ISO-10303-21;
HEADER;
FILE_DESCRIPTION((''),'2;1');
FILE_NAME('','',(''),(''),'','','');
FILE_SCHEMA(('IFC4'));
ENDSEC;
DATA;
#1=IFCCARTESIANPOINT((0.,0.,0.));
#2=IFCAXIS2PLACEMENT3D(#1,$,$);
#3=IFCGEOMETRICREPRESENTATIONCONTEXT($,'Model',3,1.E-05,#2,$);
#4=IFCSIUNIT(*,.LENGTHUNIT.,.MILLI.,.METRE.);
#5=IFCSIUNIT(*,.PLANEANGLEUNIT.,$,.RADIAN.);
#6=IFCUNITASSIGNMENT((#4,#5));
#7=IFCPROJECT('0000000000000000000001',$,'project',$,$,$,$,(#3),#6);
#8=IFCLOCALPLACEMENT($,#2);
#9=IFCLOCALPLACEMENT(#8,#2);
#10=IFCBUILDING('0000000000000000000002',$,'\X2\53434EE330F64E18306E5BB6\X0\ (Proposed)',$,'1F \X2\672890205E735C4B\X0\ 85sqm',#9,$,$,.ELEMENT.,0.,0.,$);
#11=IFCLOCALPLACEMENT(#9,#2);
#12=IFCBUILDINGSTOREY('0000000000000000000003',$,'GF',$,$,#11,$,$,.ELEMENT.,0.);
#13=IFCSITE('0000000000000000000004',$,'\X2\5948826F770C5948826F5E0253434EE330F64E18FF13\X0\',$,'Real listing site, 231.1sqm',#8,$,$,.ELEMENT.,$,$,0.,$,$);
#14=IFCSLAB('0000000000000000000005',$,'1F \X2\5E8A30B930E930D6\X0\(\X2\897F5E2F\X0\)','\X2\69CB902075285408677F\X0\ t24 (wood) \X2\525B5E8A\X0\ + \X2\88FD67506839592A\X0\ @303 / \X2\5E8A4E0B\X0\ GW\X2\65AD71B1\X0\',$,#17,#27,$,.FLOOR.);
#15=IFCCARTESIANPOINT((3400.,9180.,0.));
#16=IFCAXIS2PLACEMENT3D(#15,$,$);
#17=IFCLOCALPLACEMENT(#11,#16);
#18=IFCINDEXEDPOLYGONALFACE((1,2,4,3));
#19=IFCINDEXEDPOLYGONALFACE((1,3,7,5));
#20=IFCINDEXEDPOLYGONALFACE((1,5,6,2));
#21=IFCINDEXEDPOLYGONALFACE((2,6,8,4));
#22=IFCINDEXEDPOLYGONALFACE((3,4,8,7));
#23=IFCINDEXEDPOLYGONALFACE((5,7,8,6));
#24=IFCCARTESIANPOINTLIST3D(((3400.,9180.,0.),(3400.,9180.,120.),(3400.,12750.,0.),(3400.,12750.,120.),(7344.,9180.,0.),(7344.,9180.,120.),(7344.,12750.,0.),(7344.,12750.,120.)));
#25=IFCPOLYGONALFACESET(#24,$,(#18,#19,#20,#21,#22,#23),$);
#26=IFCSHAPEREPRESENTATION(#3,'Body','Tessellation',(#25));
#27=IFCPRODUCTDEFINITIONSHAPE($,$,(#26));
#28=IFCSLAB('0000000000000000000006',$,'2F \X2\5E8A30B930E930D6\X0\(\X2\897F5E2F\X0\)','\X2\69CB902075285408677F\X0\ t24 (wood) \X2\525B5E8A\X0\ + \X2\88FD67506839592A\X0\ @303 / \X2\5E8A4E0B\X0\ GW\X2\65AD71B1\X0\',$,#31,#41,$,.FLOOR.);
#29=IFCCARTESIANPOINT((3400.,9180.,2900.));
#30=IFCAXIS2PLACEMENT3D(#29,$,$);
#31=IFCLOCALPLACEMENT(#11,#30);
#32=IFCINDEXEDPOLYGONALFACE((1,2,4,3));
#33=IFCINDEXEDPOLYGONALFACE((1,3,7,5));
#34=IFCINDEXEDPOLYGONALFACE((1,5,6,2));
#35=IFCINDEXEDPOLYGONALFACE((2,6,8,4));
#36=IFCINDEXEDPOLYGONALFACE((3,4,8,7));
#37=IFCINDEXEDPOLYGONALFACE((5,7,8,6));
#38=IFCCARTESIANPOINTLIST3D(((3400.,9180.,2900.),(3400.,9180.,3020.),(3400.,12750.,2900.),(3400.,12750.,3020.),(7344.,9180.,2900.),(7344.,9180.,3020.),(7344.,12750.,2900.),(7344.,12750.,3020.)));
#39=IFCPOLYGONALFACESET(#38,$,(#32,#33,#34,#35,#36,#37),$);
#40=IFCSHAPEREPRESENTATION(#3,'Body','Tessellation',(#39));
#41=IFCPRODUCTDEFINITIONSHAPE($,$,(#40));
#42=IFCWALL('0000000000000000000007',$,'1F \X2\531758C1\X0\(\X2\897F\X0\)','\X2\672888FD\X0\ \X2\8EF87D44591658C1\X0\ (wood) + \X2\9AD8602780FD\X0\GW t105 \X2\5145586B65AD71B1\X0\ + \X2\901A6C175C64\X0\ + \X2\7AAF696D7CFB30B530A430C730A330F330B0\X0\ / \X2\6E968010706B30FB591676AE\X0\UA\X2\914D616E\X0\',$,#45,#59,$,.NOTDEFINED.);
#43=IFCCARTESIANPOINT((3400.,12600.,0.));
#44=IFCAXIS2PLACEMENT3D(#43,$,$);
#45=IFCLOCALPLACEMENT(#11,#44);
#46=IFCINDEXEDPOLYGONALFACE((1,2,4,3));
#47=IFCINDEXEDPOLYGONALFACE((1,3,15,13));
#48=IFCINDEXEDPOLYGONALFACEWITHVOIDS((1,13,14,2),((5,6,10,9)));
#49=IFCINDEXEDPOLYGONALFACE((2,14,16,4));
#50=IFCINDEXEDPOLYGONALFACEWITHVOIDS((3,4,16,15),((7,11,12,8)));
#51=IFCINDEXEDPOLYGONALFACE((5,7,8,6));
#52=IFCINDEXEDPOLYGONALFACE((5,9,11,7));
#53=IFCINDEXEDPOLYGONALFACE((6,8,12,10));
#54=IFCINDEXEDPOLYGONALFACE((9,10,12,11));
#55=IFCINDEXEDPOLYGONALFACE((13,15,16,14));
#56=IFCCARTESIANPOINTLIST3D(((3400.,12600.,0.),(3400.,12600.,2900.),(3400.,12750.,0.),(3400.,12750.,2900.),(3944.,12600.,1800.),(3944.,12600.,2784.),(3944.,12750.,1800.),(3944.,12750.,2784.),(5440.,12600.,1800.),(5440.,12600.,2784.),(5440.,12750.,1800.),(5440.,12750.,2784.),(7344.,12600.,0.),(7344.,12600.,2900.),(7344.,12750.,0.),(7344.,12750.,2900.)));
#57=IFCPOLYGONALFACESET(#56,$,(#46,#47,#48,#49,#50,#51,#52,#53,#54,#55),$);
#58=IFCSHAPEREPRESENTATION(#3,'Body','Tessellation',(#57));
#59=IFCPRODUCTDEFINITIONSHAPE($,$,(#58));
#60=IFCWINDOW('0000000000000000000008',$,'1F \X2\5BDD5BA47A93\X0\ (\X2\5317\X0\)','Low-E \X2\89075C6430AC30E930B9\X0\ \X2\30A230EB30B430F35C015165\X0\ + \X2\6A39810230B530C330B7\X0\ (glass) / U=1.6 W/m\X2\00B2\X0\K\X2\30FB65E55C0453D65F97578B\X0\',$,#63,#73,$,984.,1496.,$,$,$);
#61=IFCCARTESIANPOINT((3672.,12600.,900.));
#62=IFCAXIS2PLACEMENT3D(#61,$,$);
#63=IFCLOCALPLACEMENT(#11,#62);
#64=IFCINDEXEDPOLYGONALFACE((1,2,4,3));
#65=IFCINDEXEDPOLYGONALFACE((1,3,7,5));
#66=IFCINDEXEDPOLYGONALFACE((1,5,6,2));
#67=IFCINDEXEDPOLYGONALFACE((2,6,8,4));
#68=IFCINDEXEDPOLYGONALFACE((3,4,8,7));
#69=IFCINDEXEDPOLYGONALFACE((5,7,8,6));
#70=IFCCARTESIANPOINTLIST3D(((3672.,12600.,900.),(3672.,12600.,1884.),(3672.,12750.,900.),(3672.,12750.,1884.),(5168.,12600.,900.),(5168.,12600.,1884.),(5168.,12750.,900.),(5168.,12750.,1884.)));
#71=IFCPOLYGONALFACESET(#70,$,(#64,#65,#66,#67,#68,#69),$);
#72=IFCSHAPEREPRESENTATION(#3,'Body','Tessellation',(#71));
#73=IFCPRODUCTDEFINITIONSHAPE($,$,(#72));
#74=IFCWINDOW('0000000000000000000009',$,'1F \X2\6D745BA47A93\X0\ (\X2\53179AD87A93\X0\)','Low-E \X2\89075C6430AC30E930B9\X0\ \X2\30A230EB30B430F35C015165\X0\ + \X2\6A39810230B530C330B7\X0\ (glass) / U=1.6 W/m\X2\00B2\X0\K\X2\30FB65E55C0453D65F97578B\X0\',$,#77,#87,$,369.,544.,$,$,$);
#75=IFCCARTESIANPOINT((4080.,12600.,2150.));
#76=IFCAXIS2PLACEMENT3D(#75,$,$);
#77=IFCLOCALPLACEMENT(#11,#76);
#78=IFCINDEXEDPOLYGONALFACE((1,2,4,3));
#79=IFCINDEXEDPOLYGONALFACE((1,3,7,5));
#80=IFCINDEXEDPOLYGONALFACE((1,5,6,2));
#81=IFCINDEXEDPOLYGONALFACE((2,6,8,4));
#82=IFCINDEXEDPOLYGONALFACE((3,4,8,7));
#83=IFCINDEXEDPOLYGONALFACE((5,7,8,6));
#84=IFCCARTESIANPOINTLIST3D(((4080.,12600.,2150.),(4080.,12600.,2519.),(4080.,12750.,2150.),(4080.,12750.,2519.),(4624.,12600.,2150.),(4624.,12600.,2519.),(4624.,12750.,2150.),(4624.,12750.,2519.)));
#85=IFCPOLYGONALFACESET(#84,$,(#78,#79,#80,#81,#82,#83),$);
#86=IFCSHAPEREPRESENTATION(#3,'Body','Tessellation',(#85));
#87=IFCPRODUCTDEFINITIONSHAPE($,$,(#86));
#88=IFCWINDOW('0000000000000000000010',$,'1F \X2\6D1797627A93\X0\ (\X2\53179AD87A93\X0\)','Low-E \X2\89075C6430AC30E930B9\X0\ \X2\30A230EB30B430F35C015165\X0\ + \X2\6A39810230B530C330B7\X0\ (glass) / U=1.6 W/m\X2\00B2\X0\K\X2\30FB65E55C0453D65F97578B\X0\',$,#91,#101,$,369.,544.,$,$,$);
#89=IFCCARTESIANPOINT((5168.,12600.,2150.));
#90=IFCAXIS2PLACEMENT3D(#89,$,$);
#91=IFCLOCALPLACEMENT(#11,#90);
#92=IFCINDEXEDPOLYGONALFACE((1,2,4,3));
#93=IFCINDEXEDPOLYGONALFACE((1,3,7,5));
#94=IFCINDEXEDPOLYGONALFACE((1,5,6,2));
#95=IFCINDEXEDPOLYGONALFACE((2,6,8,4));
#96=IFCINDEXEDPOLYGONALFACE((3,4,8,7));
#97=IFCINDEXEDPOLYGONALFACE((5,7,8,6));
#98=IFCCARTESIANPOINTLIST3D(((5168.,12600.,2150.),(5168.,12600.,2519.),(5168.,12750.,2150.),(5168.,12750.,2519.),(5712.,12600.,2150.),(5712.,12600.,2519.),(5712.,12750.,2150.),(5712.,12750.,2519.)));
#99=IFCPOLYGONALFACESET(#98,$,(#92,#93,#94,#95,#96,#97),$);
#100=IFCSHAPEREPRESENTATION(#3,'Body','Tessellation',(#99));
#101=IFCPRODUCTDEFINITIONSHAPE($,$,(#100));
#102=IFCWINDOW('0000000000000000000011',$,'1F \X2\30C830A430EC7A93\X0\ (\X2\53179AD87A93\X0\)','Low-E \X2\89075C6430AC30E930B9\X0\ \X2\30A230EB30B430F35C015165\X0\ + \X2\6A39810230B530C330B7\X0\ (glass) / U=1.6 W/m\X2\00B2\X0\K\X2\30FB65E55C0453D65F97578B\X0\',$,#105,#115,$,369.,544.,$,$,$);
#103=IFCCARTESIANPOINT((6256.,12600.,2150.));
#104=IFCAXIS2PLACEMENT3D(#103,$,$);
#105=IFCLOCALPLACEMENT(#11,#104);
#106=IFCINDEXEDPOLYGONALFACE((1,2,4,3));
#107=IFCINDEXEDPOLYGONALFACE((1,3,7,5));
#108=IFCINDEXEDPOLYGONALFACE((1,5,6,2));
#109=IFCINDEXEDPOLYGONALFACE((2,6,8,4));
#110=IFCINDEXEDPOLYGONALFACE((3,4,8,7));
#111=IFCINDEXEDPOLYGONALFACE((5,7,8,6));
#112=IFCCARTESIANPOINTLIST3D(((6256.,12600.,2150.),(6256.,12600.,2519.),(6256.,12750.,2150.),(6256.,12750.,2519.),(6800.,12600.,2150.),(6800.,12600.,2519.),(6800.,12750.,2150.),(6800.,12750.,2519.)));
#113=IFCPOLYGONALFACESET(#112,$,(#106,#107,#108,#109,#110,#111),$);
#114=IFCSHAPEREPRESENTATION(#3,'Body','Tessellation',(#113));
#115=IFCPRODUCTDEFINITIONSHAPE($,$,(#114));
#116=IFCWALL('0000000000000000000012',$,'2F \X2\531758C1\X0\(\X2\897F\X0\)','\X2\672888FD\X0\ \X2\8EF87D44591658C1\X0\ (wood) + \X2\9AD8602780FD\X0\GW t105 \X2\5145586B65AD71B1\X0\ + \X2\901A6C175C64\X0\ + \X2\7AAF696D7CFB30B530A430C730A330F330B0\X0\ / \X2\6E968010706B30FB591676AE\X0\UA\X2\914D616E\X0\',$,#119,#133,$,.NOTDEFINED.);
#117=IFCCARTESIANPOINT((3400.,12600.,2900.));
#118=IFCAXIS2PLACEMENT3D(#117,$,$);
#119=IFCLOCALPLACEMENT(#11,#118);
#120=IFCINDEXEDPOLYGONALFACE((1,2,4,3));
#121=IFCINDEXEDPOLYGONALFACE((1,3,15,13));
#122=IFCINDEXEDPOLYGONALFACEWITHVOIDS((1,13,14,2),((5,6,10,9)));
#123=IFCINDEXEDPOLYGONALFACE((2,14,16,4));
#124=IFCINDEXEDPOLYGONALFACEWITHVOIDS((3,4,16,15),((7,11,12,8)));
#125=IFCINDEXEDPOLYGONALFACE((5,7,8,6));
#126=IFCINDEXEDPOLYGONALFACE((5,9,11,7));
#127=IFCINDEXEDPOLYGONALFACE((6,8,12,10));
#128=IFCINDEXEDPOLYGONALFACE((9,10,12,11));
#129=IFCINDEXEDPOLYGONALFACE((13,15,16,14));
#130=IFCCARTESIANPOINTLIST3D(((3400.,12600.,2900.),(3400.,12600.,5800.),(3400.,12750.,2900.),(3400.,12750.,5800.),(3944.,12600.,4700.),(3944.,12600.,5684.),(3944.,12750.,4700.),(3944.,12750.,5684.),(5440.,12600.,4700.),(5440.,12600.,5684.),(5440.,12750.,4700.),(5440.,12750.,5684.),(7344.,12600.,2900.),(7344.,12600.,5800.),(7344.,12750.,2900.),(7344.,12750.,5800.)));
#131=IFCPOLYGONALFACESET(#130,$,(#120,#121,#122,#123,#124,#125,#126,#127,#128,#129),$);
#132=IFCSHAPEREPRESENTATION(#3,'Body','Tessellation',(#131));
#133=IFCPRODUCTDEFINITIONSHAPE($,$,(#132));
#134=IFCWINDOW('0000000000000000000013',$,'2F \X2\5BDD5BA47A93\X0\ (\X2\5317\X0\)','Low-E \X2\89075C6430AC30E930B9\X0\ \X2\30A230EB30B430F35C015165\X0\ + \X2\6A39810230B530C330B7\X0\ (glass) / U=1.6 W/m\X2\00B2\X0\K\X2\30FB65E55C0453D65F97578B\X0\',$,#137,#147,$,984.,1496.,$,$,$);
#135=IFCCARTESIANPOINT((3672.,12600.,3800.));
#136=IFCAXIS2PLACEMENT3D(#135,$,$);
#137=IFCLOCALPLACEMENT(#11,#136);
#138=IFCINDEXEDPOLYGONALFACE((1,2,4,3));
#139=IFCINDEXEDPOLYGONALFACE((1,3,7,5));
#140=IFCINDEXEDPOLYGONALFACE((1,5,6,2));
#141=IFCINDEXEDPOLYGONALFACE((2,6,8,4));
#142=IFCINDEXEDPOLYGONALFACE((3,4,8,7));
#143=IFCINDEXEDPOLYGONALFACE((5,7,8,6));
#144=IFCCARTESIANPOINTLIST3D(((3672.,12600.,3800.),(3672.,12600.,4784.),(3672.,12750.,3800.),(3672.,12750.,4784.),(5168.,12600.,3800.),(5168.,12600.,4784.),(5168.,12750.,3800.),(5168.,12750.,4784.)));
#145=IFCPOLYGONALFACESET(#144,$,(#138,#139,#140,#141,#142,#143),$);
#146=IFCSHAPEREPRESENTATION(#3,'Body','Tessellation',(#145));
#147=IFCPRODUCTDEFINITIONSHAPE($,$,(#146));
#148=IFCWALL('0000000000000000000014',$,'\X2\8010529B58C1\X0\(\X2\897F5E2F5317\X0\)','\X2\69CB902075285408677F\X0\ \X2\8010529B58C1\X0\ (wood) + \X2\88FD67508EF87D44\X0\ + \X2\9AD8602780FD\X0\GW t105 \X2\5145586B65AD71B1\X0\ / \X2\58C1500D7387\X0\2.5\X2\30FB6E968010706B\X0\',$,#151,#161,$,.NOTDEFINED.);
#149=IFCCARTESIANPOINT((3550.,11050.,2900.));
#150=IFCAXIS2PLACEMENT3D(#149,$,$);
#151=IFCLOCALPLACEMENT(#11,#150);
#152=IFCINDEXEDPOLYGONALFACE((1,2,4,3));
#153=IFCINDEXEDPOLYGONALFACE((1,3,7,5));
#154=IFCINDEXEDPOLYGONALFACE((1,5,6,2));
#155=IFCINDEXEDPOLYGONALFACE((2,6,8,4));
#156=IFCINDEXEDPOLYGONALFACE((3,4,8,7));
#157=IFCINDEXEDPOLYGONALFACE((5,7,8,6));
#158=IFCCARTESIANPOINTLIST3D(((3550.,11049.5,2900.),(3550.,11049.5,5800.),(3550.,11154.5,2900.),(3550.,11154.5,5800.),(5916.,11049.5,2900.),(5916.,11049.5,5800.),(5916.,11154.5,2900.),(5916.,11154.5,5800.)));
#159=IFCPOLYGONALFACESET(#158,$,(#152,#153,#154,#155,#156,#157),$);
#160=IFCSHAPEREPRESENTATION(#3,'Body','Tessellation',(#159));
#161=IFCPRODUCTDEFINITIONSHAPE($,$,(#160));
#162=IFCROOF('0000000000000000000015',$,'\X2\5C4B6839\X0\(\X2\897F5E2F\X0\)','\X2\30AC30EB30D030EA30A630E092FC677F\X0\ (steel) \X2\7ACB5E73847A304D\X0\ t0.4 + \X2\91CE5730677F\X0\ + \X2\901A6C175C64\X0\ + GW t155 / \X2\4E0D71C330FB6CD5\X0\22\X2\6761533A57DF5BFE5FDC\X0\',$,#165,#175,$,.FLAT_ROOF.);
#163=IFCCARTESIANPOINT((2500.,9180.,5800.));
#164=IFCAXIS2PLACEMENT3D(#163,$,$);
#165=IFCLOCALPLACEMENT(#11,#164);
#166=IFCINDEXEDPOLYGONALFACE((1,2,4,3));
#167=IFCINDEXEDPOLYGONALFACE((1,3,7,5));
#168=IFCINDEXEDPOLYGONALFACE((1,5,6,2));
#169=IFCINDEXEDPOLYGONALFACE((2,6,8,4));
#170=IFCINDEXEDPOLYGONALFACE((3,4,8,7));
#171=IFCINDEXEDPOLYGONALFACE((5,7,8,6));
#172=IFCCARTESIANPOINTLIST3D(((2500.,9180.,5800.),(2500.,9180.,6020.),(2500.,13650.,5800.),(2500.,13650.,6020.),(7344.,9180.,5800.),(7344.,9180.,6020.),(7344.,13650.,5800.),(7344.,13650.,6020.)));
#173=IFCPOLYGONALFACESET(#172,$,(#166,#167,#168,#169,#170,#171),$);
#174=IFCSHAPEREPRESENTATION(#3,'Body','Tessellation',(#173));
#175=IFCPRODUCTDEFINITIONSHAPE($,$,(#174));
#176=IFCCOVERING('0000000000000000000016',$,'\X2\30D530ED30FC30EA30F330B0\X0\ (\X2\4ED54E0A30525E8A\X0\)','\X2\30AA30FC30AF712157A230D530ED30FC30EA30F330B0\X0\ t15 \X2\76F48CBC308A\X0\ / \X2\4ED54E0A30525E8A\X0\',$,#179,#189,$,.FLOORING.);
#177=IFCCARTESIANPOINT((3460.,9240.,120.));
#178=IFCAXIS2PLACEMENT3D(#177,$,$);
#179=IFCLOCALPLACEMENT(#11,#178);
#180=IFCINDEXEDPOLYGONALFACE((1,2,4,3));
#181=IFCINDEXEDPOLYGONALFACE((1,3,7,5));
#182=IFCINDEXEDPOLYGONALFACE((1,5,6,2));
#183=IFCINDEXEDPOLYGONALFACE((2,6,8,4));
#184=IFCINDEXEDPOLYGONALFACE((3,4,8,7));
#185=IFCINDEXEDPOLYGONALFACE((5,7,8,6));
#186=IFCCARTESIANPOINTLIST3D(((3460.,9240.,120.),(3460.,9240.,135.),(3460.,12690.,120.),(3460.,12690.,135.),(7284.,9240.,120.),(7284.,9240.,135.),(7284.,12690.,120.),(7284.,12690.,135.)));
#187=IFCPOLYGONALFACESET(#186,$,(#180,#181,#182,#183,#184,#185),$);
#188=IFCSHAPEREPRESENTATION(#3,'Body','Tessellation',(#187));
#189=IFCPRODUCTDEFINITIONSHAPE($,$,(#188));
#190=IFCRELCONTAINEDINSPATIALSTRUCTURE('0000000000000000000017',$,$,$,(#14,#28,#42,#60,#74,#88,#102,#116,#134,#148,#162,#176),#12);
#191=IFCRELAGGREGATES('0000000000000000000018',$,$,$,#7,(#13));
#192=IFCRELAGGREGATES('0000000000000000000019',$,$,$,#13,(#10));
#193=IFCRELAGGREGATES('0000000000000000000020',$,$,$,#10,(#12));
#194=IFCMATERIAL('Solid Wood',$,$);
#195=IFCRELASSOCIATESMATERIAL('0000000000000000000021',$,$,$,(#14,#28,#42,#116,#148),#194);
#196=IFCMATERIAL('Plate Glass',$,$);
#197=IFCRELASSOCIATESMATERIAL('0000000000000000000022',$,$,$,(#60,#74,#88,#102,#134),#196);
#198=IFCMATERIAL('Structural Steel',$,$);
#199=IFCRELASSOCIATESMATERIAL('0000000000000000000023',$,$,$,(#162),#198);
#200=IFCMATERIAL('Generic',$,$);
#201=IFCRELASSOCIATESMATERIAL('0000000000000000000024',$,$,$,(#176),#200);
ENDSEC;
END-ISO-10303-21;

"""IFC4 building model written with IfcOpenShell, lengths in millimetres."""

from ifc_helpers import new_model, si_unit, frame, frame_2d, origin, place, context, project, spatial, rectangle, extrude, material, element, fill, save


model = new_model("IFC4")

# Units and contexts
model_context = context("Model", 3, precision=1e-05, world=origin())
ifc_project = project(units=[si_unit("LENGTHUNIT", "METRE", prefix="MILLI"), si_unit("PLANEANGLEUNIT", "RADIAN")], contexts=[model_context])

# Site, building, storey
site_placement = place(None, origin())
site = spatial("IfcSite", under=ifc_project, at=site_placement, Name="奈良県奈良市千代ヶ丘３", ObjectType="Real listing site, 231.1sqm", CompositionType="ELEMENT", RefElevation=0.0)
building_placement = place(site_placement, origin())
building = spatial("IfcBuilding", under=site, at=building_placement, Name="千代ヶ丘の家 (Proposed)", ObjectType="1F 木造平屋 85sqm", CompositionType="ELEMENT", ElevationOfRefHeight=0.0, ElevationOfTerrain=0.0)
storey_placement = place(building_placement, origin())
storey = spatial("IfcBuildingStorey", under=building, at=storey_placement, Name="GF", CompositionType="ELEMENT", Elevation=0.0)

# Slabs
ifc_material_1 = material(Name="Solid Wood")
slab_1_placement = place(storey_placement, frame((3400.0, 9180.0, 0.0)))
element("IfcSlab", 1, at=slab_1_placement, inside=storey, material=ifc_material_1, Name="1F 床スラブ(西帯)", Description="構造用合板 t24 (wood) 剛床 + 製材根太 @303 / 床下 GW断熱", PredefinedType="FLOOR", context=model_context, shape_type="SweptSolid", body=[
    extrude(rectangle(XDim=3944.0, YDim=3570.0, at=frame_2d((1972.0, 1785.0))), frame((3400.0, 9180.0, 0.0)), (0.0, 0.0, 1.0), 120.0),
])
slab_2_placement = place(storey_placement, frame((3400.0, 9180.0, 2900.0)))
element("IfcSlab", 2, at=slab_2_placement, inside=storey, material=ifc_material_1, Name="2F 床スラブ(西帯)", Description="構造用合板 t24 (wood) 剛床 + 製材根太 @303 / 床下 GW断熱", PredefinedType="FLOOR", context=model_context, shape_type="SweptSolid", body=[
    extrude(rectangle(XDim=3944.0, YDim=3570.0, at=frame_2d((1972.0, 1785.0))), frame((3400.0, 9180.0, 2900.0)), (0.0, 0.0, 1.0), 120.0),
])

# Wall, openings, windows
wall_1_placement = place(storey_placement, frame((3400.0, 12600.0, 0.0)))
wall_1 = element("IfcWall", 3, at=wall_1_placement, inside=storey, material=ifc_material_1, Name="1F 北壁(西)", Description="木製 軸組外壁 (wood) + 高性能GW t105 充填断熱 + 通気層 + 窯業系サイディング / 準耐火・外皮UA配慮", PredefinedType="NOTDEFINED", context=model_context, shape_type="SweptSolid", body=[
    extrude(rectangle(XDim=3944.0, YDim=150.0, at=frame_2d((1972.0, 75.0))), frame((3400.0, 12600.0, 0.0)), (0.0, 0.0, 1.0), 2900.0),
])
opening_1_placement = place(storey_placement, frame((3672.0, 12600.0, 900.0)))
opening_1 = element("IfcOpeningElement", 4, at=opening_1_placement, cuts=wall_1, PredefinedType="NOTDEFINED", context=model_context, shape_type="SweptSolid", body=[
    extrude(rectangle(XDim=1496.0, YDim=150.0, at=frame_2d((748.0, 75.0))), frame((3672.0, 12600.0, 900.0)), (0.0, 0.0, 1.0), 984.0),
])
opening_2_placement = place(storey_placement, frame((4080.0, 12600.0, 2150.0)))
opening_2 = element("IfcOpeningElement", 5, at=opening_2_placement, cuts=wall_1, PredefinedType="NOTDEFINED", context=model_context, shape_type="SweptSolid", body=[
    extrude(rectangle(XDim=544.0, YDim=150.0, at=frame_2d((272.0, 75.0))), frame((4080.0, 12600.0, 2150.0)), (0.0, 0.0, 1.0), 369.0),
])
opening_3_placement = place(storey_placement, frame((5168.0, 12600.0, 2150.0)))
opening_3 = element("IfcOpeningElement", 6, at=opening_3_placement, cuts=wall_1, PredefinedType="NOTDEFINED", context=model_context, shape_type="SweptSolid", body=[
    extrude(rectangle(XDim=544.0, YDim=150.0, at=frame_2d((272.0, 75.0))), frame((5168.0, 12600.0, 2150.0)), (0.0, 0.0, 1.0), 369.0),
])
opening_4_placement = place(storey_placement, frame((6256.0, 12600.0, 2150.0)))
opening_4 = element("IfcOpeningElement", 7, at=opening_4_placement, cuts=wall_1, PredefinedType="NOTDEFINED", context=model_context, shape_type="SweptSolid", body=[
    extrude(rectangle(XDim=544.0, YDim=150.0, at=frame_2d((272.0, 75.0))), frame((6256.0, 12600.0, 2150.0)), (0.0, 0.0, 1.0), 369.0),
])
ifc_material_2 = material(Name="Plate Glass")
window_1_placement = place(storey_placement, frame((3672.0, 12600.0, 900.0)))
window_1 = element("IfcWindow", 8, at=window_1_placement, inside=storey, material=ifc_material_2, Name="1F 寝室窓 (北)", Description="Low-E 複層ガラス アルゴン封入 + 樹脂サッシ (glass) / U=1.6 W/m²K・日射取得型", OverallHeight=984.0, OverallWidth=1496.0, context=model_context, shape_type="SweptSolid", body=[
    extrude(rectangle(XDim=1496.0, YDim=150.0, at=frame_2d((748.0, 75.0))), frame((3672.0, 12600.0, 900.0)), (0.0, 0.0, 1.0), 984.0),
])
fill(opening_1, window_1)
window_2_placement = place(storey_placement, frame((4080.0, 12600.0, 2150.0)))
window_2 = element("IfcWindow", 9, at=window_2_placement, inside=storey, material=ifc_material_2, Name="1F 浴室窓 (北高窓)", Description="Low-E 複層ガラス アルゴン封入 + 樹脂サッシ (glass) / U=1.6 W/m²K・日射取得型", OverallHeight=369.0, OverallWidth=544.0, context=model_context, shape_type="SweptSolid", body=[
    extrude(rectangle(XDim=544.0, YDim=150.0, at=frame_2d((272.0, 75.0))), frame((4080.0, 12600.0, 2150.0)), (0.0, 0.0, 1.0), 369.0),
])
fill(opening_2, window_2)
window_3_placement = place(storey_placement, frame((5168.0, 12600.0, 2150.0)))
window_3 = element("IfcWindow", 10, at=window_3_placement, inside=storey, material=ifc_material_2, Name="1F 洗面窓 (北高窓)", Description="Low-E 複層ガラス アルゴン封入 + 樹脂サッシ (glass) / U=1.6 W/m²K・日射取得型", OverallHeight=369.0, OverallWidth=544.0, context=model_context, shape_type="SweptSolid", body=[
    extrude(rectangle(XDim=544.0, YDim=150.0, at=frame_2d((272.0, 75.0))), frame((5168.0, 12600.0, 2150.0)), (0.0, 0.0, 1.0), 369.0),
])
fill(opening_3, window_3)
window_4_placement = place(storey_placement, frame((6256.0, 12600.0, 2150.0)))
window_4 = element("IfcWindow", 11, at=window_4_placement, inside=storey, material=ifc_material_2, Name="1F トイレ窓 (北高窓)", Description="Low-E 複層ガラス アルゴン封入 + 樹脂サッシ (glass) / U=1.6 W/m²K・日射取得型", OverallHeight=369.0, OverallWidth=544.0, context=model_context, shape_type="SweptSolid", body=[
    extrude(rectangle(XDim=544.0, YDim=150.0, at=frame_2d((272.0, 75.0))), frame((6256.0, 12600.0, 2150.0)), (0.0, 0.0, 1.0), 369.0),
])
fill(opening_4, window_4)

# Wall, opening, window
wall_2_placement = place(storey_placement, frame((3400.0, 12600.0, 2900.0)))
wall_2 = element("IfcWall", 12, at=wall_2_placement, inside=storey, material=ifc_material_1, Name="2F 北壁(西)", Description="木製 軸組外壁 (wood) + 高性能GW t105 充填断熱 + 通気層 + 窯業系サイディング / 準耐火・外皮UA配慮", PredefinedType="NOTDEFINED", context=model_context, shape_type="SweptSolid", body=[
    extrude(rectangle(XDim=3944.0, YDim=150.0, at=frame_2d((1972.0, 75.0))), frame((3400.0, 12600.0, 2900.0)), (0.0, 0.0, 1.0), 2900.0),
])
opening_5_placement = place(storey_placement, frame((3672.0, 12600.0, 3800.0)))
opening_5 = element("IfcOpeningElement", 13, at=opening_5_placement, cuts=wall_2, PredefinedType="NOTDEFINED", context=model_context, shape_type="SweptSolid", body=[
    extrude(rectangle(XDim=1496.0, YDim=150.0, at=frame_2d((748.0, 75.0))), frame((3672.0, 12600.0, 3800.0)), (0.0, 0.0, 1.0), 984.0),
])
window_5_placement = place(storey_placement, frame((3672.0, 12600.0, 3800.0)))
window_5 = element("IfcWindow", 14, at=window_5_placement, inside=storey, material=ifc_material_2, Name="2F 寝室窓 (北)", Description="Low-E 複層ガラス アルゴン封入 + 樹脂サッシ (glass) / U=1.6 W/m²K・日射取得型", OverallHeight=984.0, OverallWidth=1496.0, context=model_context, shape_type="SweptSolid", body=[
    extrude(rectangle(XDim=1496.0, YDim=150.0, at=frame_2d((748.0, 75.0))), frame((3672.0, 12600.0, 3800.0)), (0.0, 0.0, 1.0), 984.0),
])
fill(opening_5, window_5)

# Wall
wall_3_placement = place(storey_placement, frame((3550.0, 11050.0, 2900.0)))
element("IfcWall", 15, at=wall_3_placement, inside=storey, material=ifc_material_1, Name="耐力壁(西帯北)", Description="構造用合板 耐力壁 (wood) + 製材軸組 + 高性能GW t105 充填断熱 / 壁倍率2.5・準耐火", PredefinedType="NOTDEFINED", context=model_context, shape_type="SweptSolid", body=[
    extrude(rectangle(XDim=2366.0, YDim=105.0, at=frame_2d((1183.0, 52.0))), frame((3550.0, 11050.0, 2900.0)), (0.0, 0.0, 1.0), 2900.0),
])

# Roof
ifc_material_3 = material(Name="Structural Steel")
for number, where, name in (
    (16, (2500.0, 9180.0, 5800.0), "屋根(西帯)"),
):
    element("IfcRoof", number, at=place(storey_placement, frame(where)), inside=storey, material=ifc_material_3, Name=name, Description="ガルバリウム鋼板 (steel) 立平葺き t0.4 + 野地板 + 通気層 + GW t155 / 不燃・法22条区域対応", PredefinedType="FLAT_ROOF", context=model_context, shape_type="SweptSolid", body=[
        extrude(rectangle(XDim=4844.0, YDim=4470.0, at=frame_2d((2422.0, 2235.0))), frame((2500.0, 9180.0, 5800.0)), (0.0, 0.0, 1.0), 220.0),
    ])

# Covering
ifc_material_4 = material(Name="Generic")
covering_1_placement = place(storey_placement, frame((3460.0, 9240.0, 120.0)))
element("IfcCovering", 17, at=covering_1_placement, inside=storey, material=ifc_material_4, Name="フローリング (仕上げ床)", Description="オーク無垢フローリング t15 直貼り / 仕上げ床", PredefinedType="FLOORING", context=model_context, shape_type="SweptSolid", body=[
    extrude(rectangle(XDim=3824.0, YDim=3450.0, at=frame_2d((1912.0, 1725.0))), frame((3460.0, 9240.0, 120.0)), (0.0, 0.0, 1.0), 15.0),
])

save(model, "model.ifc")
